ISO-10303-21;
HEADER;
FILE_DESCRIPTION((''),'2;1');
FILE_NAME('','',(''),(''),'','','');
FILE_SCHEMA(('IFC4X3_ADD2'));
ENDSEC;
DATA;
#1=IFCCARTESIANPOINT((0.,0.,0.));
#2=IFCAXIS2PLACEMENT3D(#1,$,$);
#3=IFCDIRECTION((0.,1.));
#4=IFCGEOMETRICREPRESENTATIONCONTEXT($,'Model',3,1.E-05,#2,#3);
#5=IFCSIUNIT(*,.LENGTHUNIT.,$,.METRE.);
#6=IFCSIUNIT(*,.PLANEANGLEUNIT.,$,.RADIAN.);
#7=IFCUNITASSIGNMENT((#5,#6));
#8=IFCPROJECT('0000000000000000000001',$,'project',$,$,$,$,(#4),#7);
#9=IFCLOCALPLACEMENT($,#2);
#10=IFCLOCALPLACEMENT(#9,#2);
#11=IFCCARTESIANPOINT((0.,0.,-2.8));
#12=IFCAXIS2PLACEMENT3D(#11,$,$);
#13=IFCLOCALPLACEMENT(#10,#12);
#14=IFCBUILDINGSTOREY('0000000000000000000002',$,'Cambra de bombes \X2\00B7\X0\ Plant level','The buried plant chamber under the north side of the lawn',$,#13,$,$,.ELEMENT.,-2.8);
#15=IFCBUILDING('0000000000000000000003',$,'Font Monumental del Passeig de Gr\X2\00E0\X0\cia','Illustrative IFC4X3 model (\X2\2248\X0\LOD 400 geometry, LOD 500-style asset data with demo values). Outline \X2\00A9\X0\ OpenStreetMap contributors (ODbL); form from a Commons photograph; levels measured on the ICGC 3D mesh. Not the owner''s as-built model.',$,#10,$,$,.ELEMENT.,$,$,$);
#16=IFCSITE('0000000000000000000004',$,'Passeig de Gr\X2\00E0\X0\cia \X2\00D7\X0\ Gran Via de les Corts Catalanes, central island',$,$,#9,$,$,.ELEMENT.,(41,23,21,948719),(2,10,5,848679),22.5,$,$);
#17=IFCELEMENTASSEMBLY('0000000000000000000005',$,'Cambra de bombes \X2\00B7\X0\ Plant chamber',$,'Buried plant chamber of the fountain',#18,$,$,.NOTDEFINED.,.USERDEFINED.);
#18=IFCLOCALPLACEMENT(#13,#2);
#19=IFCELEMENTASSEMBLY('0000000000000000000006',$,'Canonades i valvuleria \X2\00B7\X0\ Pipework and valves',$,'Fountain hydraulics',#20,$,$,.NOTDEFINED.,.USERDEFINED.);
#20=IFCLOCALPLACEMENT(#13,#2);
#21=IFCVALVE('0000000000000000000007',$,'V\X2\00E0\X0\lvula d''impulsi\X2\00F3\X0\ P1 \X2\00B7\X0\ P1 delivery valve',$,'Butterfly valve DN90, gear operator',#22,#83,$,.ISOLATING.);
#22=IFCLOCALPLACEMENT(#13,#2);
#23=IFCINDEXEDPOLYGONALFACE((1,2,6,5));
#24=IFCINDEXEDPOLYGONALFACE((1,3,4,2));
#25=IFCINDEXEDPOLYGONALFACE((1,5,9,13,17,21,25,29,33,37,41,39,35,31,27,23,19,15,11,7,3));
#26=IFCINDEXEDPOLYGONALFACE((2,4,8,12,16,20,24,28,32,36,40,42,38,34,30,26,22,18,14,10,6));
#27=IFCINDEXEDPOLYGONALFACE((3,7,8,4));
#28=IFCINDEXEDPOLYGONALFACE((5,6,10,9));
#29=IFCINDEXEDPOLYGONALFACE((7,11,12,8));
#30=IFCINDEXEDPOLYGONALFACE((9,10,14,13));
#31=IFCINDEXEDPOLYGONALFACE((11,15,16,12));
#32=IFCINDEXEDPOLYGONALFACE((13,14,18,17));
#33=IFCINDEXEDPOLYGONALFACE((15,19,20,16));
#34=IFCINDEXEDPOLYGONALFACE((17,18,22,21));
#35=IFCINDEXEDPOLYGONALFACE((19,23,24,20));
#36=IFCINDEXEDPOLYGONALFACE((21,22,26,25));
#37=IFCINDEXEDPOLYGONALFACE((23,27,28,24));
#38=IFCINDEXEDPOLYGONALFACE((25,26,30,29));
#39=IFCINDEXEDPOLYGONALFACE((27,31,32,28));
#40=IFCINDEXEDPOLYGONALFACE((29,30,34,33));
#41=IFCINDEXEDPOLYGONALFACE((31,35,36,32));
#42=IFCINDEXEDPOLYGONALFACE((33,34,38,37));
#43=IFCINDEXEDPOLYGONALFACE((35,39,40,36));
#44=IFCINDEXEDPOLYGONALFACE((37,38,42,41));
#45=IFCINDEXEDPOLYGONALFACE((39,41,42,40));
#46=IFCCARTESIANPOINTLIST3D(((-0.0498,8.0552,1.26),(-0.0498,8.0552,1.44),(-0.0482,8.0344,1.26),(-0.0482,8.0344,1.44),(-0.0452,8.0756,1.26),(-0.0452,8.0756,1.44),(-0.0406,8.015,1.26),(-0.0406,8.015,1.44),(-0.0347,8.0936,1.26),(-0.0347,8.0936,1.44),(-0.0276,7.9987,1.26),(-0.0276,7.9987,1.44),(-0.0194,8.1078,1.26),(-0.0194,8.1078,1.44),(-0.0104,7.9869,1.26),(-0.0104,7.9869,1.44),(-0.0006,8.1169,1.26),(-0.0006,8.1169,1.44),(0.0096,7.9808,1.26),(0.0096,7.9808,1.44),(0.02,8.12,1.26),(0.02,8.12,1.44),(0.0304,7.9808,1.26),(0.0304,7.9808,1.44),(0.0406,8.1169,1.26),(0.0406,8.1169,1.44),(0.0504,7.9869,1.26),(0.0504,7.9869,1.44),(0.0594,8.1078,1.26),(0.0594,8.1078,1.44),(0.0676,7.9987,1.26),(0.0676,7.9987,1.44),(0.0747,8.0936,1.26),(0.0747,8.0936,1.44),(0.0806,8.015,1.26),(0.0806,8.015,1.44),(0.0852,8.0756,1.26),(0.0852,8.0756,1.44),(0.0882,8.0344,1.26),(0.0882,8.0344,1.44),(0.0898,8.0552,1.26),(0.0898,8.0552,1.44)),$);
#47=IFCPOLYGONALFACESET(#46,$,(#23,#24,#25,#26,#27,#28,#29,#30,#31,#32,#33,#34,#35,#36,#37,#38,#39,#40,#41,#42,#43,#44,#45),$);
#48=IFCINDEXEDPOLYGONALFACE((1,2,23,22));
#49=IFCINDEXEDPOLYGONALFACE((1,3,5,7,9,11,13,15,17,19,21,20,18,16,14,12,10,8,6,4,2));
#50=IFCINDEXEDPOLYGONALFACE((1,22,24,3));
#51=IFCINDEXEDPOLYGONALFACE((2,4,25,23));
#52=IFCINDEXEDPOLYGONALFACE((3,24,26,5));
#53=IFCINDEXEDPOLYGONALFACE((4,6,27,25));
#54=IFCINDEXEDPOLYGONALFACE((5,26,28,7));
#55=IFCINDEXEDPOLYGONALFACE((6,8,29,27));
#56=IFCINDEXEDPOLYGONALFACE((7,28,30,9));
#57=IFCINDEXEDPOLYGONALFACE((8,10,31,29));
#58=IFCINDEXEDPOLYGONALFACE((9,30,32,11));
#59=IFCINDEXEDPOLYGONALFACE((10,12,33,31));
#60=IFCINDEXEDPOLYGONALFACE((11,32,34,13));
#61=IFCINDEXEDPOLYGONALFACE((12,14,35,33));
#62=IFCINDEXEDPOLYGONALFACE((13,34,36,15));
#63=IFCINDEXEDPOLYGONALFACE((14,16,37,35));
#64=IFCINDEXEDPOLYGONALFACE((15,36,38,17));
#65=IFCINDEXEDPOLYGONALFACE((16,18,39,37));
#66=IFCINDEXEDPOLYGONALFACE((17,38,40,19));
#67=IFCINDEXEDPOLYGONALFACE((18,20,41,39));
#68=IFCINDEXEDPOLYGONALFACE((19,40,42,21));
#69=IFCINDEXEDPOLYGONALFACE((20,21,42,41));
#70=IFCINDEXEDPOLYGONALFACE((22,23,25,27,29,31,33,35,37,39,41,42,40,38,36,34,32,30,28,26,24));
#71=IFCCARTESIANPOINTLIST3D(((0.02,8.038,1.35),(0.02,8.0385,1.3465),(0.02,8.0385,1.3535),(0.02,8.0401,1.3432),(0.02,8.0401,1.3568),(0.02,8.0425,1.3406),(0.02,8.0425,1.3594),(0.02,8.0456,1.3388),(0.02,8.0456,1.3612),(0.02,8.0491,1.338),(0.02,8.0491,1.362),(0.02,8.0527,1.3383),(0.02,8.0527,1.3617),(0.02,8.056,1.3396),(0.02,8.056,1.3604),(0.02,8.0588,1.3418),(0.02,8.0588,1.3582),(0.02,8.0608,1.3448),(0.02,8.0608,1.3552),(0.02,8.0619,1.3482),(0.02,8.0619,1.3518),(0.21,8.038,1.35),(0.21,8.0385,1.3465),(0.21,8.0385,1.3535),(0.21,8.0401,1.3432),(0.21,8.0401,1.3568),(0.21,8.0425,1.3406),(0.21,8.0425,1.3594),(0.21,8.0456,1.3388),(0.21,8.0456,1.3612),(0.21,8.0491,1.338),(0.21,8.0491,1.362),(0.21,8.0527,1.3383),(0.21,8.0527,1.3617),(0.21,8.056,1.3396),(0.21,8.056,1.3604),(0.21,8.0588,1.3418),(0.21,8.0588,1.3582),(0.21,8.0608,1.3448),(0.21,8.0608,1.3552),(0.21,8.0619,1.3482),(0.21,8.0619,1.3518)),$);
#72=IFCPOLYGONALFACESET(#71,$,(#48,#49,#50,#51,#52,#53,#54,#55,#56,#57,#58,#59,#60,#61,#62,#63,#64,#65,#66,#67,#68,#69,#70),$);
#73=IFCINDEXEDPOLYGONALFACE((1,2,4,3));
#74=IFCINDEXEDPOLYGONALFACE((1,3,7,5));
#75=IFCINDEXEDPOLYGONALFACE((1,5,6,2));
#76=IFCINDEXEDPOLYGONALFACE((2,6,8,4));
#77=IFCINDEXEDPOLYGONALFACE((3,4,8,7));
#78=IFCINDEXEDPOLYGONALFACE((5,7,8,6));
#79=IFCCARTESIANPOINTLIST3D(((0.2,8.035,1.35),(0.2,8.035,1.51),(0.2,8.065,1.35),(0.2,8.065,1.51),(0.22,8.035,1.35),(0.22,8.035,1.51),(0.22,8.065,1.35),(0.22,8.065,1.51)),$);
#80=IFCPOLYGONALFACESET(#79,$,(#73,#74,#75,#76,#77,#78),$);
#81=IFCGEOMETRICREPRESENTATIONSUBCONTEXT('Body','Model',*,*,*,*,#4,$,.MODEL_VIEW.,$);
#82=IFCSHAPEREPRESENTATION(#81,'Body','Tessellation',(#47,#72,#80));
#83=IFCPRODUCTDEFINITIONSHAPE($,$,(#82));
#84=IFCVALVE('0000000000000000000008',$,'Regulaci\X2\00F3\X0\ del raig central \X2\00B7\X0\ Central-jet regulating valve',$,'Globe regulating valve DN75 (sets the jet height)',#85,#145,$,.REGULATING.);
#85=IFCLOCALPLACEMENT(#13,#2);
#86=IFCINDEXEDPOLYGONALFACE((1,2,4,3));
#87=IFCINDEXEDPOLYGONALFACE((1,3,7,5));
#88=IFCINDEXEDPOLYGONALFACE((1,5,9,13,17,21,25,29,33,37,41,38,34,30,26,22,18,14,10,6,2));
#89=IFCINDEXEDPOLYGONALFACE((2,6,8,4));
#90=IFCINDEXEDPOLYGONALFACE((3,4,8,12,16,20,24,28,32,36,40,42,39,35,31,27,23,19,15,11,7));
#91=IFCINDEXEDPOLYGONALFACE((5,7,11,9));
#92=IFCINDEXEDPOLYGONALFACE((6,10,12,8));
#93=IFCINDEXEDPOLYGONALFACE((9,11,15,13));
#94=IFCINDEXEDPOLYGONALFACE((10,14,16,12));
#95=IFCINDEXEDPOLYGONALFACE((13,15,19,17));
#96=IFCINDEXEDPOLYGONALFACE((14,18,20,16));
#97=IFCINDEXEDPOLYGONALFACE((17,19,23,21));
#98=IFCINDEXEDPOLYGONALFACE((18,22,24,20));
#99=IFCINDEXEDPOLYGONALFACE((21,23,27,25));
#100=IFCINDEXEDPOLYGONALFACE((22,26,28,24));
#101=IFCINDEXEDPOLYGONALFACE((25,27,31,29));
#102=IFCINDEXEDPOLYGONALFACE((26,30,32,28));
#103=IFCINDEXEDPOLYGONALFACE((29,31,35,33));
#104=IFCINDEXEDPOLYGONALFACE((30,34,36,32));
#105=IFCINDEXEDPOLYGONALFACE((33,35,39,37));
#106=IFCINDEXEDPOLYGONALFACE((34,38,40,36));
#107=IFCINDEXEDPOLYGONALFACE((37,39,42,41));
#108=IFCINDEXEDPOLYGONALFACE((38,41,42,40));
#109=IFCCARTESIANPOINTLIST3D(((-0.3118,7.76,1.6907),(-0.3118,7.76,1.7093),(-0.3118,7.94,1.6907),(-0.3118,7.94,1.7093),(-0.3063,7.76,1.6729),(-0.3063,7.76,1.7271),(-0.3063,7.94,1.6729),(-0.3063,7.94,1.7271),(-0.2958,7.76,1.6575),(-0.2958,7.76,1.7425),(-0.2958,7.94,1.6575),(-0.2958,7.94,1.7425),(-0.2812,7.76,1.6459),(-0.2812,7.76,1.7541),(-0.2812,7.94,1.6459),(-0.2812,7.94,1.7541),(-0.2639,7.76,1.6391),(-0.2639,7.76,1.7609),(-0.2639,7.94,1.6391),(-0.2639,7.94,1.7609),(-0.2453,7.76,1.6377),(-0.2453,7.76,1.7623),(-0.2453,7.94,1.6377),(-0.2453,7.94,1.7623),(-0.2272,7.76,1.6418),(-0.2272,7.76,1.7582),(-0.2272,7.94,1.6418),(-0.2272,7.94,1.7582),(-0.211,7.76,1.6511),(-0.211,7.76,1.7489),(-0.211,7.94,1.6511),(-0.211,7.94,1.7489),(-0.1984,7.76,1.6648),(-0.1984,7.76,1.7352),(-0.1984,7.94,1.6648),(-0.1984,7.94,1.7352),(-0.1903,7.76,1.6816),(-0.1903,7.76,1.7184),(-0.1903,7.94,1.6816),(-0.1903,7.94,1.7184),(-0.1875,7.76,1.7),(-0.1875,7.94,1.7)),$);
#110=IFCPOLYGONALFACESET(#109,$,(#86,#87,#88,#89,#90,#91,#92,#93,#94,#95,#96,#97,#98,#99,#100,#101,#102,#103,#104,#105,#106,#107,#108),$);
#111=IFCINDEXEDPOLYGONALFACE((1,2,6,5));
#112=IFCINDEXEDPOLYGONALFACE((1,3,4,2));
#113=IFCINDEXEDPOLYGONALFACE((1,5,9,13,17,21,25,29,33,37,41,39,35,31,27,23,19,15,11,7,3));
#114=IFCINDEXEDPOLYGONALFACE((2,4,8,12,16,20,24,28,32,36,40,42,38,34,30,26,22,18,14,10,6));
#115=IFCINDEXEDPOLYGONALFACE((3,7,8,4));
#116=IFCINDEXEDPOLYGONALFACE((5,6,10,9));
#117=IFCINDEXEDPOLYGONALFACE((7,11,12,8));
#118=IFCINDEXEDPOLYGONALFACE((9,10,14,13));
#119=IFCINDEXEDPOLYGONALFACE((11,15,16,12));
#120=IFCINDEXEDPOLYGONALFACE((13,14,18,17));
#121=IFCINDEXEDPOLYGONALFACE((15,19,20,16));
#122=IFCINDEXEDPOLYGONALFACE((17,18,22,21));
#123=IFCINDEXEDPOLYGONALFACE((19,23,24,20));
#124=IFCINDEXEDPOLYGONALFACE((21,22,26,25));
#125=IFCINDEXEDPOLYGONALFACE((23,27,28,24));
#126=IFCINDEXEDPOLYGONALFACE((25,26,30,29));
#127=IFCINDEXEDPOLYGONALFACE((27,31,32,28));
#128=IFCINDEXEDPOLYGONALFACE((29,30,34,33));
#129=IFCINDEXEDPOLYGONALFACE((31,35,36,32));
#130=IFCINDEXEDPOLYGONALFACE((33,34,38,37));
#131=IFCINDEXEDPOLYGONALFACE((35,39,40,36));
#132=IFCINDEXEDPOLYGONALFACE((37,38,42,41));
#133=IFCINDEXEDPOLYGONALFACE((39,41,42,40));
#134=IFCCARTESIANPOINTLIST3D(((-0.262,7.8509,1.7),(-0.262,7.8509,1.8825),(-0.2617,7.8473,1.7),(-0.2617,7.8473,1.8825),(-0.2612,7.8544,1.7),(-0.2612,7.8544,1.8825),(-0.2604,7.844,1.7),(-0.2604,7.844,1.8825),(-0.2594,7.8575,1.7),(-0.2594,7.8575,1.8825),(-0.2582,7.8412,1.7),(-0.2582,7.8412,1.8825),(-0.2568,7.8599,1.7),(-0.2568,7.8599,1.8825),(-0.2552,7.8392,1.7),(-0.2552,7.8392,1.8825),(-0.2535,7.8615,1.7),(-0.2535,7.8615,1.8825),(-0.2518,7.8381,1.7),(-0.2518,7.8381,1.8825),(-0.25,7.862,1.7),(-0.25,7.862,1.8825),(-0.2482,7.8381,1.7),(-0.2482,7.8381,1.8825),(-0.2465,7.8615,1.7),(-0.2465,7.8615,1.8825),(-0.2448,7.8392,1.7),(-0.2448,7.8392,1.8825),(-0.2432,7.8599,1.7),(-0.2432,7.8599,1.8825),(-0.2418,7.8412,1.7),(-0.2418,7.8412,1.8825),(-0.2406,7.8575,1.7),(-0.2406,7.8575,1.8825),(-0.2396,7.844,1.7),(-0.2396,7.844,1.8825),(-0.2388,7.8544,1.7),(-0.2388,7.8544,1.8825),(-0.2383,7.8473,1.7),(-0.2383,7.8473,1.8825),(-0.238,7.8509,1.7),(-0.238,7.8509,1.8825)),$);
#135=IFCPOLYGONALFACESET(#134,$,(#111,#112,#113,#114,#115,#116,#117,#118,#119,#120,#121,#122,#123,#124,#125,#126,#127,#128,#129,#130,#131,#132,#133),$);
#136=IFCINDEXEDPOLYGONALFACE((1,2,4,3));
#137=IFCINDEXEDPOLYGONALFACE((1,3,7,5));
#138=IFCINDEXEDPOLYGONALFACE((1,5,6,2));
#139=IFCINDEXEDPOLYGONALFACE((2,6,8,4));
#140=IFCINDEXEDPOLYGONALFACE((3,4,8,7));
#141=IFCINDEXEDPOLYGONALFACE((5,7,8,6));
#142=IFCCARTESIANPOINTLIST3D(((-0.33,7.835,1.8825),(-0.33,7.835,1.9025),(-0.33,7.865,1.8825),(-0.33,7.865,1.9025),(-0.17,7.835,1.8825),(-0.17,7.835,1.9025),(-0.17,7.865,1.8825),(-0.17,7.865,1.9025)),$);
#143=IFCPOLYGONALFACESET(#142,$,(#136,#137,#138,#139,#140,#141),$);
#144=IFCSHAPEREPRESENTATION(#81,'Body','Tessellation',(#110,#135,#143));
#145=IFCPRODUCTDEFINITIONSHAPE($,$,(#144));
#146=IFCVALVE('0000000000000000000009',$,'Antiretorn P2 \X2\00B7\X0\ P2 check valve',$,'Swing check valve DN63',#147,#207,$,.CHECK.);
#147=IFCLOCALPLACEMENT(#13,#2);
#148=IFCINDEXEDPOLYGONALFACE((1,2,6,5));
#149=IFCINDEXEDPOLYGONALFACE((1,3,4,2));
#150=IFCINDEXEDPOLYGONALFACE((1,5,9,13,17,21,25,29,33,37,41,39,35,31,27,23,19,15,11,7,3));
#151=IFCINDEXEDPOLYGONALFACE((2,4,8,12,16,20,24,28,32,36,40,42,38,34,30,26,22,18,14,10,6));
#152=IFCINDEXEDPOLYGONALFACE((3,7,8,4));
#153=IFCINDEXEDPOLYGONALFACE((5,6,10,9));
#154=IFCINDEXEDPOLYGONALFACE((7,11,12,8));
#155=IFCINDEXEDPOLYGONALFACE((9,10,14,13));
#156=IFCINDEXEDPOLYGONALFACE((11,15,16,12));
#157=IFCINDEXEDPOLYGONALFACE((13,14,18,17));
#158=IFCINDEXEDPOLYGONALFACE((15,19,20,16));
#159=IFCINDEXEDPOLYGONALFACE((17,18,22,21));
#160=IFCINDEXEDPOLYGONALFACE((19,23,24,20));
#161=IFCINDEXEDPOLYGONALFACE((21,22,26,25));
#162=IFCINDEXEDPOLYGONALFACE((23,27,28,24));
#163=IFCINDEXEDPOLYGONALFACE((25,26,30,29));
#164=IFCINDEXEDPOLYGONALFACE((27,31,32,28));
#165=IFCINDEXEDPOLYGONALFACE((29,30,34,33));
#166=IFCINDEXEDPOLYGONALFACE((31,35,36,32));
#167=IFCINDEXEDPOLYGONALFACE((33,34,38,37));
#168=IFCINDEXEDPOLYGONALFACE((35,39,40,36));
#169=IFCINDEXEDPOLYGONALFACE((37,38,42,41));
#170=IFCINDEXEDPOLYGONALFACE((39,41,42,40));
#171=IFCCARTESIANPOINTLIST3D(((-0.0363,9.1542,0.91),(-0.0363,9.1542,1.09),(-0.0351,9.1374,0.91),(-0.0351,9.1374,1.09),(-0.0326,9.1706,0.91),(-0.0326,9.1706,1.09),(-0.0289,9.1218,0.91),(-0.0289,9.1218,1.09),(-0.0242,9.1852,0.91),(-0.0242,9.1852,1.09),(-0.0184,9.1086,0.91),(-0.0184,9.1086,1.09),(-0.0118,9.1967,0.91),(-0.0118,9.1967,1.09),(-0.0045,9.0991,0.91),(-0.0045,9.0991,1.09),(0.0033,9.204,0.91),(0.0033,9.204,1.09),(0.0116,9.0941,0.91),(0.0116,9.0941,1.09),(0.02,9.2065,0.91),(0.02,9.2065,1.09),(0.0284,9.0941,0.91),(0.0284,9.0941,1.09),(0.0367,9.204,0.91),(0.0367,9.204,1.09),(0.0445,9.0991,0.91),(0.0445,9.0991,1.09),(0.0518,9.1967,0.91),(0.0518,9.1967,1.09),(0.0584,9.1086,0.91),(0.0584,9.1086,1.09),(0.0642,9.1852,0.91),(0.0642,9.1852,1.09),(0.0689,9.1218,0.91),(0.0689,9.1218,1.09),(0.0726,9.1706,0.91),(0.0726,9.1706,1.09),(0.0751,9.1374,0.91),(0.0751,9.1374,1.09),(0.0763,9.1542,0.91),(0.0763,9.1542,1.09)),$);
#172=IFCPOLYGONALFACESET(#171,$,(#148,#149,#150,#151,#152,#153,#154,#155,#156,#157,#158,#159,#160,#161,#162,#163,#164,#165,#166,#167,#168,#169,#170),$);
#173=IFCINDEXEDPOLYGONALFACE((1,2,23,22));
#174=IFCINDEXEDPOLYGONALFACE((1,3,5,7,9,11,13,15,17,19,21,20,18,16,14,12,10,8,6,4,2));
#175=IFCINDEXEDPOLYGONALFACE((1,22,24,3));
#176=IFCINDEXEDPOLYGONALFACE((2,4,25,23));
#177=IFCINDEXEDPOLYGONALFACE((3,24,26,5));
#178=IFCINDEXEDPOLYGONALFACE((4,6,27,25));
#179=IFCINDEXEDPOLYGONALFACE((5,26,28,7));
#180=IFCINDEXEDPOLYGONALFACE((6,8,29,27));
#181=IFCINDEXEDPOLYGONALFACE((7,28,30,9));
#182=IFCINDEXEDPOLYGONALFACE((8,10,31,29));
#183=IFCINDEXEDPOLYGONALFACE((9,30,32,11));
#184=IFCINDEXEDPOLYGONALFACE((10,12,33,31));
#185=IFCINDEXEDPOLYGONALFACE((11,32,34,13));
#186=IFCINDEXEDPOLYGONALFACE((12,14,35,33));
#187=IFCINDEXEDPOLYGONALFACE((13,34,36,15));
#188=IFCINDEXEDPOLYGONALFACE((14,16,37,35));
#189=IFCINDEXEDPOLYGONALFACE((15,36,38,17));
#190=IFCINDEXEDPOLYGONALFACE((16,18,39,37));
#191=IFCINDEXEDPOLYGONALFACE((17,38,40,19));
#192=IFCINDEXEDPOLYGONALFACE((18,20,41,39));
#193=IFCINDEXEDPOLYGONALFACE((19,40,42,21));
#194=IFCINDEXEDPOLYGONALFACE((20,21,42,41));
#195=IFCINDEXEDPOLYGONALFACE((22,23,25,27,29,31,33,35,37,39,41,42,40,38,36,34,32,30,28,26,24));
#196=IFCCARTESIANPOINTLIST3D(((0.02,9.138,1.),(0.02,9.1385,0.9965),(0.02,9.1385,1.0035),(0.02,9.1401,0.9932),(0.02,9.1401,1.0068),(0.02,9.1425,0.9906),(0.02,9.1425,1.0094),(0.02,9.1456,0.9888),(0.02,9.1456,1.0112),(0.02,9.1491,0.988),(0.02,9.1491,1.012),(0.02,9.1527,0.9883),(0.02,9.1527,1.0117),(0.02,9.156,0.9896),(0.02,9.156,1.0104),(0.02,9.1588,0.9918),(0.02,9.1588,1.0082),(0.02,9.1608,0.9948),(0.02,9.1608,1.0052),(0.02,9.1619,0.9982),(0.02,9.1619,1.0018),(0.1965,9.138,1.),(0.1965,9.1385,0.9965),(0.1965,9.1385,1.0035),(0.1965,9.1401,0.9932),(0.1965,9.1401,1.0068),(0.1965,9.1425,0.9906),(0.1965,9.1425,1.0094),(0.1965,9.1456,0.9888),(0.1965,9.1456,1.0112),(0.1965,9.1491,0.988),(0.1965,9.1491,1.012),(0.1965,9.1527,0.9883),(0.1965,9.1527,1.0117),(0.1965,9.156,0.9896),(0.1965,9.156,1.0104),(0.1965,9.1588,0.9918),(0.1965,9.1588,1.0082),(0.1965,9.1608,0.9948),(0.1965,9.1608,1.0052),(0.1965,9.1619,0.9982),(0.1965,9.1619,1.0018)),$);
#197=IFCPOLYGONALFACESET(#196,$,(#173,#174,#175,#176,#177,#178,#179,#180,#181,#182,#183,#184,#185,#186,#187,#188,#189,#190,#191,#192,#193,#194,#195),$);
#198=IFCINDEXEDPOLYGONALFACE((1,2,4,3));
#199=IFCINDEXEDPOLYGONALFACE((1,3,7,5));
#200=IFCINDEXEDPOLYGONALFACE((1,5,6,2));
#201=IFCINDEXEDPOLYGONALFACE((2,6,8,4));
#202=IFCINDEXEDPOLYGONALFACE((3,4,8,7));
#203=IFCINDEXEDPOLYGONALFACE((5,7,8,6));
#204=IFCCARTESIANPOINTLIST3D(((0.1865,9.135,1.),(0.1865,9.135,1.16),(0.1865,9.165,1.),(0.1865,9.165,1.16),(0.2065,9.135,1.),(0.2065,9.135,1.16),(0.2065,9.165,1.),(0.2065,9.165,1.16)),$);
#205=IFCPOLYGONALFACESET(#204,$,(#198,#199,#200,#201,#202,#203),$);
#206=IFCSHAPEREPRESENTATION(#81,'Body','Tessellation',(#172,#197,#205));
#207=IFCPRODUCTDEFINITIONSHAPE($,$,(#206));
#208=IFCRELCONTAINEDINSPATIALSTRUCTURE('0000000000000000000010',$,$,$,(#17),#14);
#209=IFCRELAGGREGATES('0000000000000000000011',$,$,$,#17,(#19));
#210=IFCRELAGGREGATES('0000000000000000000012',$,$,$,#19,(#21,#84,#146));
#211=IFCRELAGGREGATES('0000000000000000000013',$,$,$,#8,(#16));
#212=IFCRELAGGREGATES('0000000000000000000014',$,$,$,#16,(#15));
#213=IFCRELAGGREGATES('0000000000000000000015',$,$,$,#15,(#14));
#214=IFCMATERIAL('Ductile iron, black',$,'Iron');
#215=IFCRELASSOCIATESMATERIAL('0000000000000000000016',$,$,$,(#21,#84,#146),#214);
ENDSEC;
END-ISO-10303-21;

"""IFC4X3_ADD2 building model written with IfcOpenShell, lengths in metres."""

from ifc_helpers import new_model, si_unit, direction, frame, origin, origin_2d_with_axis, place, context, subcontext, project, spatial, rectangle, circle, extrude, material, element, aggregate, save


model = new_model("IFC4X3_ADD2")

# Units and contexts
model_context = context("Model", 3, precision=1e-05, world=origin(), true_north=direction((0.0, 1.0)))
body_context = subcontext(model_context, "Body", "Model", "MODEL_VIEW")
ifc_project = project(units=[si_unit("LENGTHUNIT", "METRE"), si_unit("PLANEANGLEUNIT", "RADIAN")], contexts=[model_context])

# Site, building, storey
site_placement = place(None, origin())
site = spatial("IfcSite", under=ifc_project, at=site_placement, Name="Passeig de Gràcia × Gran Via de les Corts Catalanes, central island", CompositionType="ELEMENT", RefLatitude=(41, 23, 21, 948719), RefLongitude=(2, 10, 5, 848679), RefElevation=22.5)
building_placement = place(site_placement, origin())
building = spatial("IfcBuilding", under=site, at=building_placement, Name="Font Monumental del Passeig de Gràcia", Description="Illustrative IFC4X3 model (≈LOD 400 geometry, LOD 500-style asset data with demo values). Outline © OpenStreetMap contributors (ODbL); form from a Commons photograph; levels measured on the ICGC 3D mesh. Not the owner's as-built model.", CompositionType="ELEMENT")
storey_placement = place(building_placement, frame((0.0, 0.0, -2.8)))
storey = spatial("IfcBuildingStorey", under=building, at=storey_placement, Name="Cambra de bombes · Plant level", Description="The buried plant chamber under the north side of the lawn", CompositionType="ELEMENT", Elevation=-2.8)

# Element assemblies, valves
assembly_1_placement = place(building_placement, origin())
assembly_1 = element("IfcElementAssembly", 1, at=assembly_1_placement, inside=storey, Name="Cambra de bombes · Plant chamber", ObjectType="Buried plant chamber of the fountain", AssemblyPlace="NOTDEFINED", PredefinedType="USERDEFINED")
ifc_material_1 = material(Name="Ductile iron, black", Category="Iron")
assembly_2_placement = place(building_placement, origin())
assembly_2 = element("IfcElementAssembly", 2, at=assembly_2_placement, Name="Canonades i valvuleria · Pipework and valves", ObjectType="Fountain hydraulics", AssemblyPlace="NOTDEFINED", PredefinedType="USERDEFINED")
aggregate(assembly_1, [assembly_2])
valve_1_placement = place(building_placement, origin())
valve_1 = element("IfcValve", 3, at=valve_1_placement, material=ifc_material_1, Name="Vàlvula d'impulsió P1 · P1 delivery valve", ObjectType="Butterfly valve DN90, gear operator", PredefinedType="ISOLATING", context=body_context, shape_type="SweptSolid", body=[
    extrude(circle(Radius=0.07, at=origin_2d_with_axis()), frame((0.02, 8.05, -1.54), z_axis=(0.0, 0.0, 1.0), x_axis=(0.0, 1.0, 0.0)), (0.0, 0.0, 1.0), 0.18),
    extrude(circle(Radius=0.012, at=origin_2d_with_axis()), frame((0.02, 8.05, -1.45), z_axis=(1.0, 0.0, 0.0), x_axis=(0.0, -1.0, 0.0)), (0.0, 0.0, 1.0), 0.19),
    extrude(rectangle(XDim=0.02, YDim=0.03, at=origin_2d_with_axis()), frame((0.21, 8.05, -1.45)), (0.0, 0.0, 1.0), 0.16),
])
valve_2_placement = place(building_placement, origin())
valve_2 = element("IfcValve", 4, at=valve_2_placement, material=ifc_material_1, Name="Regulació del raig central · Central-jet regulating valve", ObjectType="Globe regulating valve DN75 (sets the jet height)", PredefinedType="REGULATING", context=body_context, shape_type="SweptSolid", body=[
    extrude(circle(Radius=0.0625, at=origin_2d_with_axis()), frame((-0.25, 7.76, -1.1), z_axis=(0.0, 1.0, 0.0), x_axis=(1.0, 0.0, 0.0)), (0.0, 0.0, 1.0), 0.18),
    extrude(circle(Radius=0.012, at=origin_2d_with_axis()), frame((-0.25, 7.85, -1.1), z_axis=(0.0, 0.0, 1.0), x_axis=(0.0, 1.0, 0.0)), (0.0, 0.0, 1.0), 0.1825),
    extrude(rectangle(XDim=0.16, YDim=0.03, at=origin_2d_with_axis()), frame((-0.25, 7.85, -0.9175)), (0.0, 0.0, 1.0), 0.02),
])
valve_3_placement = place(building_placement, origin())
valve_3 = element("IfcValve", 5, at=valve_3_placement, material=ifc_material_1, Name="Antiretorn P2 · P2 check valve", ObjectType="Swing check valve DN63", PredefinedType="CHECK", context=body_context, shape_type="SweptSolid", body=[
    extrude(circle(Radius=0.0565, at=origin_2d_with_axis()), frame((0.02, 9.15, -1.89), z_axis=(0.0, 0.0, 1.0), x_axis=(0.0, 1.0, 0.0)), (0.0, 0.0, 1.0), 0.18),
    extrude(circle(Radius=0.012, at=origin_2d_with_axis()), frame((0.02, 9.15, -1.8), z_axis=(1.0, 0.0, 0.0), x_axis=(0.0, -1.0, 0.0)), (0.0, 0.0, 1.0), 0.1765),
    extrude(rectangle(XDim=0.02, YDim=0.03, at=origin_2d_with_axis()), frame((0.1965, 9.15, -1.8)), (0.0, 0.0, 1.0), 0.16),
])
aggregate(assembly_2, [valve_1, valve_2, valve_3])

save(model, "model.ifc")
